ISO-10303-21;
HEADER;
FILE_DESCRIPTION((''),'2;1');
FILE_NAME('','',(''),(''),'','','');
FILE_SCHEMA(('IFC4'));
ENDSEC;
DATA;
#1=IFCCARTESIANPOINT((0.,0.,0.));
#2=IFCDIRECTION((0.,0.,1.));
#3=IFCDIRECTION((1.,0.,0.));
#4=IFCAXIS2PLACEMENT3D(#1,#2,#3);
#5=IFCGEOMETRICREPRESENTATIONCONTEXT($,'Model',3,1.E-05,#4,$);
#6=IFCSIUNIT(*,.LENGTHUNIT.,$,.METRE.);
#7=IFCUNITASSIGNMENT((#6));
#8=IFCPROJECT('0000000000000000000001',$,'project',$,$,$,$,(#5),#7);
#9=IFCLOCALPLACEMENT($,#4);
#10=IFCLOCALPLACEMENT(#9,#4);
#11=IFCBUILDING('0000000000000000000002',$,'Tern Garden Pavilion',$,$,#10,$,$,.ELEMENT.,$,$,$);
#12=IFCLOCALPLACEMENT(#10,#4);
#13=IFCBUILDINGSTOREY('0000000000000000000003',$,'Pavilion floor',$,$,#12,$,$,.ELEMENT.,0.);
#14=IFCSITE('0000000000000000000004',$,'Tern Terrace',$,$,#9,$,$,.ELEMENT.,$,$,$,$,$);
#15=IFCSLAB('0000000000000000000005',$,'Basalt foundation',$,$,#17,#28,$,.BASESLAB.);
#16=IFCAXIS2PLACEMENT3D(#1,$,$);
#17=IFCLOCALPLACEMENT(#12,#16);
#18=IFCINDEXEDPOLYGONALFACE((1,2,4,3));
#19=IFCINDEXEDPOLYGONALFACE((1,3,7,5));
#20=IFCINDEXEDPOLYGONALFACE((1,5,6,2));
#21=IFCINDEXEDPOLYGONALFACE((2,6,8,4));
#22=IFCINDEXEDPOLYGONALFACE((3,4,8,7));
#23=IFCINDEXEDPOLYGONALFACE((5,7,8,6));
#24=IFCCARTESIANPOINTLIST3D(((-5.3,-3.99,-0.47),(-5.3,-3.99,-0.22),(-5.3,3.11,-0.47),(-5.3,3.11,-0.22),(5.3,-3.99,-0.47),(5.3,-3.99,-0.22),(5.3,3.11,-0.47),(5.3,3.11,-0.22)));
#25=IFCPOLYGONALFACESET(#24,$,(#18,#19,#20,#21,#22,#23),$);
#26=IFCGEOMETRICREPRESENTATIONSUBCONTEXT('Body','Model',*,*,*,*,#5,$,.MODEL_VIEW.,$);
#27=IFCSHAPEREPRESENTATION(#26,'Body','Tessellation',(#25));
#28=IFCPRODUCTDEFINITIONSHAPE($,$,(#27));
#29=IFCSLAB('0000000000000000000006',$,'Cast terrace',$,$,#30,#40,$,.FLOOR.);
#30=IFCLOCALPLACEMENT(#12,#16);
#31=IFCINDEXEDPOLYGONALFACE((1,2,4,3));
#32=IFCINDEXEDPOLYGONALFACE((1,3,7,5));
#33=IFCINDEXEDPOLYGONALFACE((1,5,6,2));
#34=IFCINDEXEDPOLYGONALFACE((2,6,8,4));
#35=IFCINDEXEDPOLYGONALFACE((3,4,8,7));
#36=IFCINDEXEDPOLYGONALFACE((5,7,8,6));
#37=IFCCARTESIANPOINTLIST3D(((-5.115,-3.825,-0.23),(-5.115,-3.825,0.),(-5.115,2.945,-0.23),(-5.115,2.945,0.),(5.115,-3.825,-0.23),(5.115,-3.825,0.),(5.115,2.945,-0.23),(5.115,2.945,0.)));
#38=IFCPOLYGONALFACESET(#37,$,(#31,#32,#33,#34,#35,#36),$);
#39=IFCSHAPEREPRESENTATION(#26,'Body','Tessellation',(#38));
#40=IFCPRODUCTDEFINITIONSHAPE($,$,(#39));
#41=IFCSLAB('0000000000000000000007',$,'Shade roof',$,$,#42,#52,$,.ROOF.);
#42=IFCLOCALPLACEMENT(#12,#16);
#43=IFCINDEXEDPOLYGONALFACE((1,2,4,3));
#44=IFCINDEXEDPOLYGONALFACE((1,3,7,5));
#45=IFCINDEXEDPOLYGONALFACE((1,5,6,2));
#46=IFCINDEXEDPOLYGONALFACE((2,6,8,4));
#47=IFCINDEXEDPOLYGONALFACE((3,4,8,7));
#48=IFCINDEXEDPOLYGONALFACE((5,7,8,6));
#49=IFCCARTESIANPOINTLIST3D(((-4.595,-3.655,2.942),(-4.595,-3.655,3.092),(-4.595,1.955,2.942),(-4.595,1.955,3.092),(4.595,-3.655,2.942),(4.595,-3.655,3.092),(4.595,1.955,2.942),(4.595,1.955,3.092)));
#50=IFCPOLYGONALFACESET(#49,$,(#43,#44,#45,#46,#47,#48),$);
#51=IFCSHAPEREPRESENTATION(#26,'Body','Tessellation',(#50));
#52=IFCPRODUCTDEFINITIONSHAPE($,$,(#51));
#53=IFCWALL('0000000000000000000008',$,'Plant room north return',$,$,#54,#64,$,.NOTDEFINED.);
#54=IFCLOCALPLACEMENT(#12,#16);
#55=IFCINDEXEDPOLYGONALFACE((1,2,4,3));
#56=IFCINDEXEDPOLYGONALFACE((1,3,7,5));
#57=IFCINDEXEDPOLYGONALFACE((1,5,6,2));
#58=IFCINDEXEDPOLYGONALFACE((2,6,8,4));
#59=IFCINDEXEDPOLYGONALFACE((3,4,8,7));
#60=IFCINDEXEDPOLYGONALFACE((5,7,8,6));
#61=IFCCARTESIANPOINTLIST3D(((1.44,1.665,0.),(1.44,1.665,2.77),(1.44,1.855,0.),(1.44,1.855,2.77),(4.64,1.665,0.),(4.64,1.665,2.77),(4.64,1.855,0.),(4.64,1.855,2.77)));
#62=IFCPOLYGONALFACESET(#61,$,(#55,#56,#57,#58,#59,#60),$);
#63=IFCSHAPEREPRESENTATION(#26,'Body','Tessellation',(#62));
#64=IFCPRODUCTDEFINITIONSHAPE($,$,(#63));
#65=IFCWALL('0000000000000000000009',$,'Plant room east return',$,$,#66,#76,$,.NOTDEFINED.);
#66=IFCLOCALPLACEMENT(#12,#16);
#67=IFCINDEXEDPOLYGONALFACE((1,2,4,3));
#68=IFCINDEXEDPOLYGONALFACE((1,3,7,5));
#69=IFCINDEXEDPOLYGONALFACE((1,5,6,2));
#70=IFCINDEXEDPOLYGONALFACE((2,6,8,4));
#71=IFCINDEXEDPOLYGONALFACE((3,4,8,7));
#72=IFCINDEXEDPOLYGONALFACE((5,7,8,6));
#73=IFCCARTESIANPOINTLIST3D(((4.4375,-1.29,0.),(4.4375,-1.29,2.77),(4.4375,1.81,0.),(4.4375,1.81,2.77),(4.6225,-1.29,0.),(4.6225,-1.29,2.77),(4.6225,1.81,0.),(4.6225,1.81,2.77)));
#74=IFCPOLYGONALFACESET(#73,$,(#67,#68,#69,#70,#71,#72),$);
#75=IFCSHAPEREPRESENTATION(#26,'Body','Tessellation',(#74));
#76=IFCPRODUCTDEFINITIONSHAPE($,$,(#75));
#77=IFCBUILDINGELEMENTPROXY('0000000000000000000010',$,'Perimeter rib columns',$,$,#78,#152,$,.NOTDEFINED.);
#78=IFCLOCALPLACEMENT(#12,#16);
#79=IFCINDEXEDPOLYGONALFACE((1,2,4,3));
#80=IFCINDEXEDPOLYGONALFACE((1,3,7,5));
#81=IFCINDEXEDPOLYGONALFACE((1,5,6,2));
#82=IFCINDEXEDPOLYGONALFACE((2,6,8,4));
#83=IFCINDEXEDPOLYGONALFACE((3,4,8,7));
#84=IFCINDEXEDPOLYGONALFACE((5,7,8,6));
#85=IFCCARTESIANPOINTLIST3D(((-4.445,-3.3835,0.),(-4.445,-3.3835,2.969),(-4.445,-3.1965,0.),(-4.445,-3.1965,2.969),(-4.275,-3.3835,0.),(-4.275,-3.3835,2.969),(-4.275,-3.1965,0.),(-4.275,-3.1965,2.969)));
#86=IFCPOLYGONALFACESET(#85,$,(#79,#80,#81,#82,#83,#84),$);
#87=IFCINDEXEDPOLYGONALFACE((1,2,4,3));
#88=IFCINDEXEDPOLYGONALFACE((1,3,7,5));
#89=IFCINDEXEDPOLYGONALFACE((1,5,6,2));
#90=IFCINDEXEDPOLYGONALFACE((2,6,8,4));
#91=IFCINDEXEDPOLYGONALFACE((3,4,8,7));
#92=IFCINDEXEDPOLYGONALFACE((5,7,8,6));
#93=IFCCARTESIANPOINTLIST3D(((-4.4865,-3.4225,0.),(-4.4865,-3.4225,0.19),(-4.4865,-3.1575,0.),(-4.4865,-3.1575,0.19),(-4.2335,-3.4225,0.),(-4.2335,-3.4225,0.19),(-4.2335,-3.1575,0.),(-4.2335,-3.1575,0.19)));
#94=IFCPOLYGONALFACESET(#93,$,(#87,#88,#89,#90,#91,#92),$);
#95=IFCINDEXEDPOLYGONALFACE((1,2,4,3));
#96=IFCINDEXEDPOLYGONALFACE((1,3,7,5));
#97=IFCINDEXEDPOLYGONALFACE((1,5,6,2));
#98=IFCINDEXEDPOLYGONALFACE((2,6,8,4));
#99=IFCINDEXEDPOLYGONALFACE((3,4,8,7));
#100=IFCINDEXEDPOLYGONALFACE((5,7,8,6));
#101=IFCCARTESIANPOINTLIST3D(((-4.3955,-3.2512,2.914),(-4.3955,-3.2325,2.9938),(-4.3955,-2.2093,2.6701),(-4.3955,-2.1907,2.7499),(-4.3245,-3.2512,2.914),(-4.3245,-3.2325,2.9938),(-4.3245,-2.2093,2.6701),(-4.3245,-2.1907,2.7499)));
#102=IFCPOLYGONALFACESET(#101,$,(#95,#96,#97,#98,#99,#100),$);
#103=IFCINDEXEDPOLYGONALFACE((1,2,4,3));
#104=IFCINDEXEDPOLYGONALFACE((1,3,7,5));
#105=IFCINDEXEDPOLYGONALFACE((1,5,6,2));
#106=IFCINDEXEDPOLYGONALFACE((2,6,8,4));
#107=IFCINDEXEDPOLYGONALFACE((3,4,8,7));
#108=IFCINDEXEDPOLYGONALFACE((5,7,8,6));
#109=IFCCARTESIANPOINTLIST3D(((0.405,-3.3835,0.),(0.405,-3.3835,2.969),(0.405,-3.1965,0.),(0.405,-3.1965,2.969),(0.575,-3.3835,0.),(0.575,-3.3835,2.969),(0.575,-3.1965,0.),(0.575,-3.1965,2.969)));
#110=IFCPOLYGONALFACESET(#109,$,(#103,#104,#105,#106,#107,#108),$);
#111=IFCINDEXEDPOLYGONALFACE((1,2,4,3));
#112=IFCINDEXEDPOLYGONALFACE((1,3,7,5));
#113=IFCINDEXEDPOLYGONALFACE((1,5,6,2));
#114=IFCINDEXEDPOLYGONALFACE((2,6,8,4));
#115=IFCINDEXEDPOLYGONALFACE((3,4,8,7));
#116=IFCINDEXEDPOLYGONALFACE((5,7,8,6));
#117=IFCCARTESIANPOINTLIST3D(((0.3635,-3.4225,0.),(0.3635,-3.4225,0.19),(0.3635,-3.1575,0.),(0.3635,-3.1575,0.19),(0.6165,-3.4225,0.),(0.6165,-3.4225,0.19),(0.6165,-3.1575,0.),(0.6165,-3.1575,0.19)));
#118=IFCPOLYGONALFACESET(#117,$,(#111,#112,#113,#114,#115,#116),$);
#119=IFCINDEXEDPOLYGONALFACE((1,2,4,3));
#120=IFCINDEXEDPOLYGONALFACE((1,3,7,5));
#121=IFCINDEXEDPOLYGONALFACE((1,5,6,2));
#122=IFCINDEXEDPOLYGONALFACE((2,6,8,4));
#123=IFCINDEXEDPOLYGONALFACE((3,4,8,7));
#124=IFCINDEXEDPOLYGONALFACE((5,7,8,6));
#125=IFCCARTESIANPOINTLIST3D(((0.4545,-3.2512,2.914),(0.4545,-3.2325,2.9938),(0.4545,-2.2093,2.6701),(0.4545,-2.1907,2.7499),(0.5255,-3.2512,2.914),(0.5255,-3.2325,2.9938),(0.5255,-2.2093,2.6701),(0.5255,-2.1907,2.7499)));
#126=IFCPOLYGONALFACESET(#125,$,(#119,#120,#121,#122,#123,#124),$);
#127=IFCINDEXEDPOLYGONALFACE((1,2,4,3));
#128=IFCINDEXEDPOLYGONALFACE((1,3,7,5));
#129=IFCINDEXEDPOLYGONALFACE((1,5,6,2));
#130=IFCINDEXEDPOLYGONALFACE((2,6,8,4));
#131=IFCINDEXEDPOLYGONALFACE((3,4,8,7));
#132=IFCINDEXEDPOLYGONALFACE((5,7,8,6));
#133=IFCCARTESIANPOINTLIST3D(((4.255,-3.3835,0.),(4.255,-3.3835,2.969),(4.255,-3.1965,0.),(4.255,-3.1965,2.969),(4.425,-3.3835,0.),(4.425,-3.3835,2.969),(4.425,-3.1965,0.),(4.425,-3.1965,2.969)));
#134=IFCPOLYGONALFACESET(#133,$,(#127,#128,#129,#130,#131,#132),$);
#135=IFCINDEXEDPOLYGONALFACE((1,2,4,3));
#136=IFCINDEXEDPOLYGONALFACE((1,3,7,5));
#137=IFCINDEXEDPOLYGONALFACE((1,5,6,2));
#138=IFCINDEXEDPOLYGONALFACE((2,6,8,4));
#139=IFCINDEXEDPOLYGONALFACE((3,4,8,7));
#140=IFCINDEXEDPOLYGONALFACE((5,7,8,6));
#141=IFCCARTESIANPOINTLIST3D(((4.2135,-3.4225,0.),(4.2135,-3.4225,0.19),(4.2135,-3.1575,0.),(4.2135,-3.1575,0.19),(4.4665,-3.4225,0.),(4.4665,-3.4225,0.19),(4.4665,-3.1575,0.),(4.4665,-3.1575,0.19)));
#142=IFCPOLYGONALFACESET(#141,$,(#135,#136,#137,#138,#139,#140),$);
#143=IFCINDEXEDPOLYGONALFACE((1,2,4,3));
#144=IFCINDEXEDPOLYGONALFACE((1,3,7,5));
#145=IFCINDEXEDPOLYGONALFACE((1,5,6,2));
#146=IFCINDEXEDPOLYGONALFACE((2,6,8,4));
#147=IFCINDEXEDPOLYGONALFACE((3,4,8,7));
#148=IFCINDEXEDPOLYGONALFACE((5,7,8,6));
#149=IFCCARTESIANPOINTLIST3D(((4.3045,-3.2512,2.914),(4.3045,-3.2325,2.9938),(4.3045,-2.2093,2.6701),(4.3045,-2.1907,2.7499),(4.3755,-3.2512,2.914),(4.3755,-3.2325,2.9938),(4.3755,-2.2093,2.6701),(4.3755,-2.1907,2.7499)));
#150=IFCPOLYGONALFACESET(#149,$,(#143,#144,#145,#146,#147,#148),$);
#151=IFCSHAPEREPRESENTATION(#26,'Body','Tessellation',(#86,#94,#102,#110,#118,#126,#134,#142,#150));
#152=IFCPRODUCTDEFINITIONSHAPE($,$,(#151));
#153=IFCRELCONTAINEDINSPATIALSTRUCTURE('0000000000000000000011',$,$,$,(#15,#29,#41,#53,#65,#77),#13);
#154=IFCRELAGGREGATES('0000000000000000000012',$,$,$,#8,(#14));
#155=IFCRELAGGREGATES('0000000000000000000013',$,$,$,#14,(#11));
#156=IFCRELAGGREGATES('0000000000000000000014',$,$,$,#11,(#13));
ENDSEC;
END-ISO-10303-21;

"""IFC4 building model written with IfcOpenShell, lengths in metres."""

from ifc_helpers import new_model, si_unit, frame, origin_with_axes, origin_2d, place, context, subcontext, project, spatial, rectangle, extrude, element, save


model = new_model("IFC4")

# Units and contexts
model_context = context("Model", 3, precision=1e-05, world=origin_with_axes())
body_context = subcontext(model_context, "Body", "Model", "MODEL_VIEW")
ifc_project = project(units=[si_unit("LENGTHUNIT", "METRE")], contexts=[model_context])

# Site, building, storey
site_placement = place(None, origin_with_axes())
site = spatial("IfcSite", under=ifc_project, at=site_placement, Name="Tern Terrace", CompositionType="ELEMENT")
building_placement = place(site_placement, origin_with_axes())
building = spatial("IfcBuilding", under=site, at=building_placement, Name="Tern Garden Pavilion", CompositionType="ELEMENT")
storey_placement = place(building_placement, origin_with_axes())
storey = spatial("IfcBuildingStorey", under=building, at=storey_placement, Name="Pavilion floor", CompositionType="ELEMENT", Elevation=0.0)

# Slabs
slab_1_placement = place(storey_placement, frame((0.0, -0.44, -0.47), z_axis=(0.0, 0.0, 1.0), x_axis=(1.0, 0.0, 0.0)))
element("IfcSlab", 1, at=slab_1_placement, inside=storey, Name="Basalt foundation", PredefinedType="BASESLAB", context=body_context, shape_type="SweptSolid", body=[
    extrude(rectangle(XDim=10.6, YDim=7.1, at=origin_2d()), origin_with_axes(), (0.0, 0.0, 1.0), 0.25),
])
slab_2_placement = place(storey_placement, frame((0.0, -0.44, -0.23), z_axis=(0.0, 0.0, 1.0), x_axis=(1.0, 0.0, 0.0)))
element("IfcSlab", 2, at=slab_2_placement, inside=storey, Name="Cast terrace", PredefinedType="FLOOR", context=body_context, shape_type="SweptSolid", body=[
    extrude(rectangle(XDim=10.23, YDim=6.77, at=origin_2d()), origin_with_axes(), (0.0, 0.0, 1.0), 0.23),
])
slab_3_placement = place(storey_placement, frame((0.0, -0.85, 2.942), z_axis=(0.0, 0.0, 1.0), x_axis=(1.0, 0.0, 0.0)))
element("IfcSlab", 3, at=slab_3_placement, inside=storey, Name="Shade roof", PredefinedType="ROOF", context=body_context, shape_type="SweptSolid", body=[
    extrude(rectangle(XDim=9.19, YDim=5.61, at=origin_2d()), origin_with_axes(), (0.0, 0.0, 1.0), 0.15),
])

# Walls
wall_1_placement = place(storey_placement, frame((3.04, 1.76, 0.0), z_axis=(0.0, 0.0, 1.0), x_axis=(1.0, 0.0, 0.0)))
element("IfcWall", 4, at=wall_1_placement, inside=storey, Name="Plant room north return", PredefinedType="NOTDEFINED", context=body_context, shape_type="SweptSolid", body=[
    extrude(rectangle(XDim=3.2, YDim=0.19, at=origin_2d()), origin_with_axes(), (0.0, 0.0, 1.0), 2.77),
])
wall_2_placement = place(storey_placement, frame((4.53, 0.26, 0.0), z_axis=(0.0, 0.0, 1.0), x_axis=(1.0, 0.0, 0.0)))
element("IfcWall", 5, at=wall_2_placement, inside=storey, Name="Plant room east return", PredefinedType="NOTDEFINED", context=body_context, shape_type="SweptSolid", body=[
    extrude(rectangle(XDim=0.185, YDim=3.1, at=origin_2d()), origin_with_axes(), (0.0, 0.0, 1.0), 2.77),
])

# Building element proxy
proxy_1_placement = place(storey_placement, origin_with_axes())
element("IfcBuildingElementProxy", 6, at=proxy_1_placement, inside=storey, Name="Perimeter rib columns", PredefinedType="NOTDEFINED", context=body_context, shape_type="SweptSolid", body=[
    extrude(rectangle(XDim=0.17, YDim=0.187, at=origin_2d()), frame((-4.36, -3.29, 0.0), z_axis=(0.0, 0.0, 1.0), x_axis=(1.0, 0.0, 0.0)), (0.0, 0.0, 1.0), 2.969),
    extrude(rectangle(XDim=0.253, YDim=0.265, at=origin_2d()), frame((-4.36, -3.29, 0.0), z_axis=(0.0, 0.0, 1.0), x_axis=(1.0, 0.0, 0.0)), (0.0, 0.0, 1.0), 0.19),
    extrude(rectangle(XDim=0.071, YDim=0.082, at=origin_2d()), frame((-4.36, -2.2, 2.71), z_axis=(0.0, -0.974, 0.228), x_axis=(1.0, 0.0, 0.0)), (0.0, 0.0, 1.0), 1.07),
    extrude(rectangle(XDim=0.17, YDim=0.187, at=origin_2d()), frame((0.49, -3.29, 0.0), z_axis=(0.0, 0.0, 1.0), x_axis=(1.0, 0.0, 0.0)), (0.0, 0.0, 1.0), 2.969),
    extrude(rectangle(XDim=0.253, YDim=0.265, at=origin_2d()), frame((0.49, -3.29, 0.0), z_axis=(0.0, 0.0, 1.0), x_axis=(1.0, 0.0, 0.0)), (0.0, 0.0, 1.0), 0.19),
    extrude(rectangle(XDim=0.071, YDim=0.082, at=origin_2d()), frame((0.49, -2.2, 2.71), z_axis=(0.0, -0.974, 0.228), x_axis=(1.0, 0.0, 0.0)), (0.0, 0.0, 1.0), 1.07),
    extrude(rectangle(XDim=0.17, YDim=0.187, at=origin_2d()), frame((4.34, -3.29, 0.0), z_axis=(0.0, 0.0, 1.0), x_axis=(1.0, 0.0, 0.0)), (0.0, 0.0, 1.0), 2.969),
    extrude(rectangle(XDim=0.253, YDim=0.265, at=origin_2d()), frame((4.34, -3.29, 0.0), z_axis=(0.0, 0.0, 1.0), x_axis=(1.0, 0.0, 0.0)), (0.0, 0.0, 1.0), 0.19),
    extrude(rectangle(XDim=0.071, YDim=0.082, at=origin_2d()), frame((4.34, -2.2, 2.71), z_axis=(0.0, -0.974, 0.228), x_axis=(1.0, 0.0, 0.0)), (0.0, 0.0, 1.0), 1.07),
])

save(model, "model.ifc")
